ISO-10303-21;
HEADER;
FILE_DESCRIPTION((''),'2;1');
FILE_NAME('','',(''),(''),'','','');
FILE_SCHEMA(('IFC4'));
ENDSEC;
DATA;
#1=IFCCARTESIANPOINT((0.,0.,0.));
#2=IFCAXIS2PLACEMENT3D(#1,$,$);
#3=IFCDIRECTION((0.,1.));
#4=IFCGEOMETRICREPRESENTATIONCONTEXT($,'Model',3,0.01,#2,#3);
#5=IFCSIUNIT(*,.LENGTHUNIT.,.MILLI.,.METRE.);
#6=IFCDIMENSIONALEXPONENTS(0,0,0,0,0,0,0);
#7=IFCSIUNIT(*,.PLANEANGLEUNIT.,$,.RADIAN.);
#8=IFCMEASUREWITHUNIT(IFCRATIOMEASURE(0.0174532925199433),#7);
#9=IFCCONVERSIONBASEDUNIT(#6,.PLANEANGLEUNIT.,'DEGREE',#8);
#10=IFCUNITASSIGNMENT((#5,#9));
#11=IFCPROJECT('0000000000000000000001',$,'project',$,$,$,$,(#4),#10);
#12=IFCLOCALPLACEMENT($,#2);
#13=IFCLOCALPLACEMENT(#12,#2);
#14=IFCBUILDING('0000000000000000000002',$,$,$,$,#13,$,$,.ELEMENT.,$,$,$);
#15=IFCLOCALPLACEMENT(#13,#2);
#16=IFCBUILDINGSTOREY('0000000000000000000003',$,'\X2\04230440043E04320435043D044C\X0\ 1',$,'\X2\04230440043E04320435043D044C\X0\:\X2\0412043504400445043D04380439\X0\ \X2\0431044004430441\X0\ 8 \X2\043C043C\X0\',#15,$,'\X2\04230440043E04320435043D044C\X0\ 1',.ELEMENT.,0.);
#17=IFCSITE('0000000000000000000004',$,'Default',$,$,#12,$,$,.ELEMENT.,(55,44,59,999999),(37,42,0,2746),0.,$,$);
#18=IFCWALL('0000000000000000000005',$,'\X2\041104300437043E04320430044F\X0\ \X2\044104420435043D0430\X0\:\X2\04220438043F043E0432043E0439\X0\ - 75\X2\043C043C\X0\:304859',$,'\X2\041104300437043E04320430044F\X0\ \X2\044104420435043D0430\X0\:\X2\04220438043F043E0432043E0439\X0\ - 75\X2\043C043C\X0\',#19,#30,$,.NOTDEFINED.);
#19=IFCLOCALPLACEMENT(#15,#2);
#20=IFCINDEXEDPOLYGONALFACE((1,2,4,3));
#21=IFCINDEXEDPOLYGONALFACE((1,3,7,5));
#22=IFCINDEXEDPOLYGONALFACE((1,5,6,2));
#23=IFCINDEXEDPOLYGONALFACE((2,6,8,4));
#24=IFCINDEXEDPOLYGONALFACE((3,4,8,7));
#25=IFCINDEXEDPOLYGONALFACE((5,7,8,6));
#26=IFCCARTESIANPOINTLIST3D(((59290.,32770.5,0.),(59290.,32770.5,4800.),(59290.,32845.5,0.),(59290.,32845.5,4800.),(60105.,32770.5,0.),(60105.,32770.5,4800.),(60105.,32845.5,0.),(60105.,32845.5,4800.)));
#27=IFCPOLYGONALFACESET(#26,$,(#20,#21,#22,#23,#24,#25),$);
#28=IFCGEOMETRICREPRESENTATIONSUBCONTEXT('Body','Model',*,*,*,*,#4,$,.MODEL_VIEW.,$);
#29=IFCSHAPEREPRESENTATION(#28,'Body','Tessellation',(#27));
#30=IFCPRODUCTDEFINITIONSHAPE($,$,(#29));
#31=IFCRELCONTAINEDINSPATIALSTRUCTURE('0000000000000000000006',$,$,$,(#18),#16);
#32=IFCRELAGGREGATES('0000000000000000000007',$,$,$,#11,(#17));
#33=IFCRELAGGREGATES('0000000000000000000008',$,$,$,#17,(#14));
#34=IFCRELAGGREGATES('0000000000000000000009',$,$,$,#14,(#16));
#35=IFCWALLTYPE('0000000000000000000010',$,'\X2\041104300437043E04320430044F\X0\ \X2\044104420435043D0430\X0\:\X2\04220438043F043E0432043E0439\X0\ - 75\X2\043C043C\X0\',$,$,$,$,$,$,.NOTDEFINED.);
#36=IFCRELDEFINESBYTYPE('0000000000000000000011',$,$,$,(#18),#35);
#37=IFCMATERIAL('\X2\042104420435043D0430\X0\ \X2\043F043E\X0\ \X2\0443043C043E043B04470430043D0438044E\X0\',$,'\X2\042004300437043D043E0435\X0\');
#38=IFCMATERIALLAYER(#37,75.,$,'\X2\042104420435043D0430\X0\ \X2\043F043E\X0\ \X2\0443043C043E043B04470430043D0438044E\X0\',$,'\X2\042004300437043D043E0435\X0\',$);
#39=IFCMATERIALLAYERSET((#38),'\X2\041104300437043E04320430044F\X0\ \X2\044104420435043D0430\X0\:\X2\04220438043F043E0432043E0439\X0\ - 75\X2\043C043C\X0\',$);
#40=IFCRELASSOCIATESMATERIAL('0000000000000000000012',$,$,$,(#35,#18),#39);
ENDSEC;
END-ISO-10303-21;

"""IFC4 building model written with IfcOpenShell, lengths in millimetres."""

from ifc_helpers import new_model, entity, si_unit, converted_unit, direction, frame, frame_2d, origin, place, context, subcontext, project, spatial, rectangle, extrude, material, layer, layer_set, layer_usage, type_object, element, save


model = new_model("IFC4")

# Units and contexts
model_context = context("Model", 3, precision=0.01, world=origin(), true_north=direction((0.0, 1.0)))
body_context = subcontext(model_context, "Body", "Model", "MODEL_VIEW")
ifc_project = project(units=[si_unit("LENGTHUNIT", "METRE", prefix="MILLI"), converted_unit("PLANEANGLEUNIT", "DEGREE", entity("IfcRatioMeasure", 0.0174532925199433), si_unit("PLANEANGLEUNIT", "RADIAN"), dimensions=[0, 0, 0, 0, 0, 0, 0])], contexts=[model_context])

# Site, building, storey
site_placement = place(None, origin())
site = spatial("IfcSite", under=ifc_project, at=site_placement, Name="Default", CompositionType="ELEMENT", RefLatitude=(55, 44, 59, 999999), RefLongitude=(37, 42, 0, 2746), RefElevation=0.0)
building_placement = place(site_placement, origin())
building = spatial("IfcBuilding", under=site, at=building_placement, CompositionType="ELEMENT")
storey_placement = place(building_placement, origin())
storey = spatial("IfcBuildingStorey", under=building, at=storey_placement, Name="Уровень 1", ObjectType="Уровень:Верхний брус 8 мм", LongName="Уровень 1", CompositionType="ELEMENT", Elevation=0.0)

# Shared definitions
ifc_material = material(Name="Стена по умолчанию", Category="Разное")

# Wall
ifc_layer_1 = layer(ifc_material, 75.0, Name="Стена по умолчанию", Category="Разное")
ifc_layer_set_1 = layer_set([ifc_layer_1], Name="Базовая стена:Типовой - 75мм")
wall_type_1 = type_object("IfcWallType", Name="Базовая стена:Типовой - 75мм", PredefinedType="NOTDEFINED", material=ifc_layer_set_1)
ifc_layer_usage_1 = layer_usage(ifc_layer_set_1, "AXIS2", "NEGATIVE", 37.5)
wall_1_placement = place(storey_placement, frame((59290.0, 32808.0, 0.0)))
element("IfcWall", 1, at=wall_1_placement, inside=storey, type_object=wall_type_1, material=ifc_layer_usage_1, Name="Базовая стена:Типовой - 75мм:304859", ObjectType="Базовая стена:Типовой - 75мм", PredefinedType="NOTDEFINED", context=body_context, shape_type="SweptSolid", body=[
    extrude(rectangle(XDim=815.0, YDim=75.0, at=frame_2d((407.5, 0.0), x_axis=(-1.0, 0.0))), origin(), (0.0, 0.0, 1.0), 4800.0),
])

save(model, "model.ifc")
